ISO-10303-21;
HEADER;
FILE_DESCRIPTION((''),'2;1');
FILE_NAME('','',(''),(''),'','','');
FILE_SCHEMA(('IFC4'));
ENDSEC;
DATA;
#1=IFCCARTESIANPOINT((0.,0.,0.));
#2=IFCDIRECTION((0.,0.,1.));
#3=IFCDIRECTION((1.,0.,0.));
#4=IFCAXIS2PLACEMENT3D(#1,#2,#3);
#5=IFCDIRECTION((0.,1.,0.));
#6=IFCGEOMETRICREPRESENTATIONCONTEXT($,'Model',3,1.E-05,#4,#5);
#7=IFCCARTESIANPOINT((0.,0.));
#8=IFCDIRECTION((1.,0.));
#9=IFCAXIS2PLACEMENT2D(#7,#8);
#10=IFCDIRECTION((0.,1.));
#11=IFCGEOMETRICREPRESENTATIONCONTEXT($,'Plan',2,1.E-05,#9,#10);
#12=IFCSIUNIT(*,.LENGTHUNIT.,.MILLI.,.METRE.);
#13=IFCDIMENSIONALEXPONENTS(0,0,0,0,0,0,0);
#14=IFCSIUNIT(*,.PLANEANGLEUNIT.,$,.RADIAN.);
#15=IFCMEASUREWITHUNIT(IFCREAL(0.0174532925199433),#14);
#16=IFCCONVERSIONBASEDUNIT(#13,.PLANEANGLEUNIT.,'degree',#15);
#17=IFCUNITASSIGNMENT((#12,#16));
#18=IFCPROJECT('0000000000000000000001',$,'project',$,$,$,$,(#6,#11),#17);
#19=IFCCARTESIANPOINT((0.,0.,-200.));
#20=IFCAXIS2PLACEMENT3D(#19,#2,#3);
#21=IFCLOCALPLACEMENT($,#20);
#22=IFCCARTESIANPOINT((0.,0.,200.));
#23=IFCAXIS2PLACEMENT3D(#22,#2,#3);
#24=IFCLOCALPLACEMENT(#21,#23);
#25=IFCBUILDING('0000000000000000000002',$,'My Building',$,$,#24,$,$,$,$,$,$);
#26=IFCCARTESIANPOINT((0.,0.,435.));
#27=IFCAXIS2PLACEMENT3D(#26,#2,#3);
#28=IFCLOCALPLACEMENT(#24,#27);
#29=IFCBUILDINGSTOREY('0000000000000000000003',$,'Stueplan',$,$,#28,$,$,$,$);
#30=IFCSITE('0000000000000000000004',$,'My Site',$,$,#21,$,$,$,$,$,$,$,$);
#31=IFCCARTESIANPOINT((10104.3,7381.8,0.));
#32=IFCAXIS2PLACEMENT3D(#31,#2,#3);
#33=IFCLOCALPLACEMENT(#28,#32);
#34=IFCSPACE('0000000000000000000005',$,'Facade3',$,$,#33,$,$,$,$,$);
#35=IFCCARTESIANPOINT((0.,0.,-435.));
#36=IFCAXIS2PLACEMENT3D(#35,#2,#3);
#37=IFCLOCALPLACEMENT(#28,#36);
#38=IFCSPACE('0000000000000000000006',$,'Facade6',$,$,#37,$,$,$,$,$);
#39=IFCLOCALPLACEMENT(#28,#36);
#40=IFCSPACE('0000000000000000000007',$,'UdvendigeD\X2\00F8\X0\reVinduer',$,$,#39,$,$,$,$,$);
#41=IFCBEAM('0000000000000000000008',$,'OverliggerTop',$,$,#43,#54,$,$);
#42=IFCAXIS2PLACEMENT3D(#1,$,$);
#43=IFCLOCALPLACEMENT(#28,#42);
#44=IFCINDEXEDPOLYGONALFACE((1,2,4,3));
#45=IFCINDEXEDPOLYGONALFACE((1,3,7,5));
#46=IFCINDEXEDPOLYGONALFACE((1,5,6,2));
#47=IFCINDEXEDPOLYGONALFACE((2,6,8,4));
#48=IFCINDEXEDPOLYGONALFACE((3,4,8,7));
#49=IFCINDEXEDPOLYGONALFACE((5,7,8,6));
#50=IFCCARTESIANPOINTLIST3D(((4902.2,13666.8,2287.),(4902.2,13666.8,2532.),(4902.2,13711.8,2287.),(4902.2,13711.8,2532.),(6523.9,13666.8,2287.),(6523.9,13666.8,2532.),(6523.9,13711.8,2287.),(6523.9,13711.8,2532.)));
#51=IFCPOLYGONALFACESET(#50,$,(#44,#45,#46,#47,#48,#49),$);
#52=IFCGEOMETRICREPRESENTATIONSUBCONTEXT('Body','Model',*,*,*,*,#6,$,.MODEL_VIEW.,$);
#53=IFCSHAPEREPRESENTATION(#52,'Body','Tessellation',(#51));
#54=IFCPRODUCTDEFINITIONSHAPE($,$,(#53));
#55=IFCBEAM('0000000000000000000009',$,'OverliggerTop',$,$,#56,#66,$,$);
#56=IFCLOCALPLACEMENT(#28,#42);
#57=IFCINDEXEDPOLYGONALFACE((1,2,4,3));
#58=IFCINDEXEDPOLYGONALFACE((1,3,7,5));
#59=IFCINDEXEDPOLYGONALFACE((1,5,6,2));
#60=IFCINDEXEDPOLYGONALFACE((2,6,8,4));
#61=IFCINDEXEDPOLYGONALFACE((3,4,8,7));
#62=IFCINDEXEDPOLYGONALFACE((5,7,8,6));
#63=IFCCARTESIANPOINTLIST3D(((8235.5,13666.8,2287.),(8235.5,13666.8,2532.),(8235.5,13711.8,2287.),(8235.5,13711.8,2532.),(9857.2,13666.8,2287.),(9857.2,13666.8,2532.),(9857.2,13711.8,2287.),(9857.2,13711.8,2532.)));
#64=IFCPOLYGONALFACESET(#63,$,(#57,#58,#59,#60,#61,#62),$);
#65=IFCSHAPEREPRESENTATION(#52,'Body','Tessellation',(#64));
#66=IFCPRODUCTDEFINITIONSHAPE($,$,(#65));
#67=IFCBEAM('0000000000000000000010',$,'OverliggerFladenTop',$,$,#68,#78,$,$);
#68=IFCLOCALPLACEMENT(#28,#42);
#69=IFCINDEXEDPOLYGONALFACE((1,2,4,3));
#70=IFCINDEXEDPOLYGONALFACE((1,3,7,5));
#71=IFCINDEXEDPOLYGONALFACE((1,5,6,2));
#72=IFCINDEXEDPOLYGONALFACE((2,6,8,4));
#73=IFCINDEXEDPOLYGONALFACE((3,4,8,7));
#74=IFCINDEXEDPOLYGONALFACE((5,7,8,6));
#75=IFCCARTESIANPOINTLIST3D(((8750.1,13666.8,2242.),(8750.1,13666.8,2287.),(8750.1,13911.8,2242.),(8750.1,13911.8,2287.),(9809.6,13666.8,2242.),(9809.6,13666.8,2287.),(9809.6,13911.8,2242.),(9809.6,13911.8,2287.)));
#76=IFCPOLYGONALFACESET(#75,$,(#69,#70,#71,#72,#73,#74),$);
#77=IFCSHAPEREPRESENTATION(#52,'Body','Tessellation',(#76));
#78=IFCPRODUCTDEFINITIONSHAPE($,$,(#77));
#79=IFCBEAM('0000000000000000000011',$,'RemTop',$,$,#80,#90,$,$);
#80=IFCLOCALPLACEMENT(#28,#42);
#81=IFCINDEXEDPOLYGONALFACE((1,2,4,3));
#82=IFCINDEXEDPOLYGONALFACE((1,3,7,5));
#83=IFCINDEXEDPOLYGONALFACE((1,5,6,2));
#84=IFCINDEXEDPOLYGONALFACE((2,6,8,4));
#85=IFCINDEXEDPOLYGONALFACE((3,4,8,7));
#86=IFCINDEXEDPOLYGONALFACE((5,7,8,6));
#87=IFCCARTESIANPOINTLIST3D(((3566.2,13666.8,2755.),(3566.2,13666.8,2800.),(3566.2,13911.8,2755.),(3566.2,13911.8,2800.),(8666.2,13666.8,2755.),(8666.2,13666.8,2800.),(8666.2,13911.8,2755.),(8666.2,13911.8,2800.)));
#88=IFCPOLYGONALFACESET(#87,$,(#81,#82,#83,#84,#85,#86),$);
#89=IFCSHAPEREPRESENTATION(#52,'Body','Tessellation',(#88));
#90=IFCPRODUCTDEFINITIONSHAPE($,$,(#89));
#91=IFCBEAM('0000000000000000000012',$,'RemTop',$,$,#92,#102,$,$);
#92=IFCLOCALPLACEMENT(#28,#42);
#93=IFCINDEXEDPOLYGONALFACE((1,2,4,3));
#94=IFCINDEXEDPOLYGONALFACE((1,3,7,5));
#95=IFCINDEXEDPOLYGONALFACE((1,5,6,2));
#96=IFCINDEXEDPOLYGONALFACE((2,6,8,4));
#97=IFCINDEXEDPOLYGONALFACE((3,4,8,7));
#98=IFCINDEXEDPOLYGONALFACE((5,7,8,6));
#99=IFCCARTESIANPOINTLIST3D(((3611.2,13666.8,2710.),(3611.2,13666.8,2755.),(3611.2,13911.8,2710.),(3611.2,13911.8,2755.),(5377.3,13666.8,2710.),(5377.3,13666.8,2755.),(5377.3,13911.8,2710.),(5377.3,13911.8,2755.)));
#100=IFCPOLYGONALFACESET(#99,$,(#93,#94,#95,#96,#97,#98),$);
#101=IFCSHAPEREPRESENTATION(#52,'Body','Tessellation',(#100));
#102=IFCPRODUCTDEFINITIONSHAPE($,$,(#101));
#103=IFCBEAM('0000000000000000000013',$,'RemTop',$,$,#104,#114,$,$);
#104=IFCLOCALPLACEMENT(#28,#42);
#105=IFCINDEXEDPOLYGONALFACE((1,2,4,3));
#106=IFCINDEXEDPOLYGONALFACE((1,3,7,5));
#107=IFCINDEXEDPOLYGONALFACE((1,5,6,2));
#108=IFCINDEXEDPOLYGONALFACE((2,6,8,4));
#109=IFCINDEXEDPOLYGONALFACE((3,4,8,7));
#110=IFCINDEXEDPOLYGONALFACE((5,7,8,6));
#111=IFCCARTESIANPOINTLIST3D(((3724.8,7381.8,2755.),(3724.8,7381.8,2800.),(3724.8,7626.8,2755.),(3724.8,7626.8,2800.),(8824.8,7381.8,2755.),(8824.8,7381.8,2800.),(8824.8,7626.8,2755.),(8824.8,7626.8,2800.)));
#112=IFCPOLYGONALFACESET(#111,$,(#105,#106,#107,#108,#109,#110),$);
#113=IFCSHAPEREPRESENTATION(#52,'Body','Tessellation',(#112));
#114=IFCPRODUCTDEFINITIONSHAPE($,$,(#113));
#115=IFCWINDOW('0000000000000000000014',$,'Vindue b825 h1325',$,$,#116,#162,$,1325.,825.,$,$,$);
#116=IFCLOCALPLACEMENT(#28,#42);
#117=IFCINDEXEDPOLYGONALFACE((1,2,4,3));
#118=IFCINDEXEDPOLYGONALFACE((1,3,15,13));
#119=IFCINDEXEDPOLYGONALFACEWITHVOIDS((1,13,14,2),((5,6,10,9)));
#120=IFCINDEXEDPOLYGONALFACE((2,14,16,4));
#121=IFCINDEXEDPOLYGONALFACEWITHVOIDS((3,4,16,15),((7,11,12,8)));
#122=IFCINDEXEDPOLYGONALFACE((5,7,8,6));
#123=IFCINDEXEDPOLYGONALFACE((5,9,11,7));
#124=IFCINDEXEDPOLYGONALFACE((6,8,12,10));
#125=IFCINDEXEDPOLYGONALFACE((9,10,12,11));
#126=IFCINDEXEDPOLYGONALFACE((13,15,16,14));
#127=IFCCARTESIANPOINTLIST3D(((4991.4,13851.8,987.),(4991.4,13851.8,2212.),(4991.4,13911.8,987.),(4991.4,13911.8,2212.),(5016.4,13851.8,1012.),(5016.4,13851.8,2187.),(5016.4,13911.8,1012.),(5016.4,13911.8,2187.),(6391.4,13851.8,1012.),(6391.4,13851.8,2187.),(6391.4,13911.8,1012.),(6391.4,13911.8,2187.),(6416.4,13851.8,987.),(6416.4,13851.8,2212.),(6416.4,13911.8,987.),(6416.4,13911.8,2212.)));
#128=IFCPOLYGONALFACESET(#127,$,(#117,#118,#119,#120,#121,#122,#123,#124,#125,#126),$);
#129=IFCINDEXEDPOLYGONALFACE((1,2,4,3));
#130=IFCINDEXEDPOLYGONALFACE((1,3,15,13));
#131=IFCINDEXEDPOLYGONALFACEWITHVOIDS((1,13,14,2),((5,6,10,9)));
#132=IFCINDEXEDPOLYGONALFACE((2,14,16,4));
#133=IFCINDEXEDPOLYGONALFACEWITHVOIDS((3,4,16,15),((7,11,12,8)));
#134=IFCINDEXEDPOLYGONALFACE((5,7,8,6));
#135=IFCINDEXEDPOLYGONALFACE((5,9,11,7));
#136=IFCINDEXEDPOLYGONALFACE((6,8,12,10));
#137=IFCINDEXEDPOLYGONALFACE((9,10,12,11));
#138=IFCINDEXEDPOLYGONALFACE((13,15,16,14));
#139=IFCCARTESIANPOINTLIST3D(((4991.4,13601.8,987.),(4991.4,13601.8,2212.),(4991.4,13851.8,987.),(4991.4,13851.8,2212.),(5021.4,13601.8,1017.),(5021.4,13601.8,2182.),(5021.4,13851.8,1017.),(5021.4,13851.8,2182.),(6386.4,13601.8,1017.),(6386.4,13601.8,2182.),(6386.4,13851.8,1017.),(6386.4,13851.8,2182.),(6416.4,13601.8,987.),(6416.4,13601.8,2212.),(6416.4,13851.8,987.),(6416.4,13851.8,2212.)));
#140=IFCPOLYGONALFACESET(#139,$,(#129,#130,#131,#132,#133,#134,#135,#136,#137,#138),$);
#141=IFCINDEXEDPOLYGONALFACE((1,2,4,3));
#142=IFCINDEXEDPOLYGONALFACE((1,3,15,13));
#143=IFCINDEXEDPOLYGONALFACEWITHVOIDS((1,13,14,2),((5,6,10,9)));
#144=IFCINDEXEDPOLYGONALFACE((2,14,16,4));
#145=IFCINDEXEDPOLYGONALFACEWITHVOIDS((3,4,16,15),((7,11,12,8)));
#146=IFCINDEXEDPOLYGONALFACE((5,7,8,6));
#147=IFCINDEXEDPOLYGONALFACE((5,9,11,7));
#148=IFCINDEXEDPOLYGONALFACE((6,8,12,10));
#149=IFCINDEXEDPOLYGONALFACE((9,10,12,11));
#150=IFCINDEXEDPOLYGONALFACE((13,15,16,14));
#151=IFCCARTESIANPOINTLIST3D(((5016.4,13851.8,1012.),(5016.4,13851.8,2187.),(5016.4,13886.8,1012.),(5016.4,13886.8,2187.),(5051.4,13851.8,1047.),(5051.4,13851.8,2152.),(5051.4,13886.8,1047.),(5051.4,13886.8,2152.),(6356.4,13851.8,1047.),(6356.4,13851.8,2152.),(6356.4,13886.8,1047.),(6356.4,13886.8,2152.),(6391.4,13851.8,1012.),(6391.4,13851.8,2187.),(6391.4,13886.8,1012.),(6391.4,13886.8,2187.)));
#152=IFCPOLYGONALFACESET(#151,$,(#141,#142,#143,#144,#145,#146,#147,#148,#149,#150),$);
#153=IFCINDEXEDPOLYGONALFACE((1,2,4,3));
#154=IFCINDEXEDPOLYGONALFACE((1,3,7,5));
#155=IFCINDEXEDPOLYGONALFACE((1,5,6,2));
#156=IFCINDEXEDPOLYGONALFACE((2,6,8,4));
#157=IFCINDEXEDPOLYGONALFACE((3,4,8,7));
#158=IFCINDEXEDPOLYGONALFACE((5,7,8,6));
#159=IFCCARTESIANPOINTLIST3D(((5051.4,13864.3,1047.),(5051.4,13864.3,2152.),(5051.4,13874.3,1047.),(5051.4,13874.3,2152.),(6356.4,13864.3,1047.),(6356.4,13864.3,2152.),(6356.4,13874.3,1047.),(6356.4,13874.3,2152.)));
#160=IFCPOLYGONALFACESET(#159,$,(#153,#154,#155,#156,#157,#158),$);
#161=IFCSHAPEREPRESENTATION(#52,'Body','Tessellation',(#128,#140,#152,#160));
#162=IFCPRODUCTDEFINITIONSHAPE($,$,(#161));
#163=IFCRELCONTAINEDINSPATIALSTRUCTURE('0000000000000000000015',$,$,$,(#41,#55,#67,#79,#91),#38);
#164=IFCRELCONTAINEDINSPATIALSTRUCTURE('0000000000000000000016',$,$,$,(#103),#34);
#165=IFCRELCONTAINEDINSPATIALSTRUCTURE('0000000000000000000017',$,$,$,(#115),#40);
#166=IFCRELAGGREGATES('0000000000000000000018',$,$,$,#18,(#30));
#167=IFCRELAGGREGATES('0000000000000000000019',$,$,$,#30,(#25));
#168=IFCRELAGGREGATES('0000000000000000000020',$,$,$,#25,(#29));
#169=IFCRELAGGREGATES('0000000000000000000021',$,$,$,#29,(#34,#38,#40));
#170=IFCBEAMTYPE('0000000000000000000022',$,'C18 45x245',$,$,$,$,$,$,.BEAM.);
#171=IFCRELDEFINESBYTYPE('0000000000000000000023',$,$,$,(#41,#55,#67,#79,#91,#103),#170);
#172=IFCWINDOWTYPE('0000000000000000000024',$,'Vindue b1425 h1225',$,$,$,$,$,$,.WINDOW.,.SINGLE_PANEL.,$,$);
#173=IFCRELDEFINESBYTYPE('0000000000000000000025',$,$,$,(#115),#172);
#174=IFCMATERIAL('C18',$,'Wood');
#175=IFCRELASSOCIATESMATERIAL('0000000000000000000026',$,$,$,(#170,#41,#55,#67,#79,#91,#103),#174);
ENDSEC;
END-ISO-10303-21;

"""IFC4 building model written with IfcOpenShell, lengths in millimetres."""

from ifc_helpers import new_model, entity, si_unit, converted_unit, direction, frame, origin_with_axes, origin_2d_with_axis, place, context, subcontext, project, spatial, line, indexed_curve, rectangle, outline, extrude, shape, source, transform, mapped, material, material_profile, profile_set, profile_usage, type_object, type_shapes, element, save


model = new_model("IFC4")

# Units and contexts
model_context = context("Model", 3, precision=1e-05, world=origin_with_axes(), true_north=direction((0.0, 1.0, 0.0)))
plan_context = context("Plan", 2, precision=1e-05, world=origin_2d_with_axis(), true_north=direction((0.0, 1.0)))
body_context_1 = subcontext(model_context, "Body", "Model", "MODEL_VIEW")
body_context_2 = subcontext(plan_context, "Body", "Plan", "PLAN_VIEW")
ifc_project = project(units=[si_unit("LENGTHUNIT", "METRE", prefix="MILLI"), converted_unit("PLANEANGLEUNIT", "degree", entity("IfcReal", 0.0174532925199433), si_unit("PLANEANGLEUNIT", "RADIAN"), dimensions=[0, 0, 0, 0, 0, 0, 0])], contexts=[model_context, plan_context])

# Site, building, storey, space
site_placement = place(None, frame((0.0, 0.0, -200.0), z_axis=(0.0, 0.0, 1.0), x_axis=(1.0, 0.0, 0.0)))
site = spatial("IfcSite", under=ifc_project, at=site_placement, Name="My Site")
building_placement = place(site_placement, frame((0.0, 0.0, 200.0), z_axis=(0.0, 0.0, 1.0), x_axis=(1.0, 0.0, 0.0)))
building = spatial("IfcBuilding", under=site, at=building_placement, Name="My Building")
storey_placement = place(building_placement, frame((0.0, 0.0, 435.0), z_axis=(0.0, 0.0, 1.0), x_axis=(1.0, 0.0, 0.0)))
storey = spatial("IfcBuildingStorey", under=building, at=storey_placement, Name="Stueplan")
space_1_placement = place(storey_placement, frame((10104.3, 7381.8, 0.0), z_axis=(0.0, 0.0, 1.0), x_axis=(1.0, 0.0, 0.0)))
space_1 = spatial("IfcSpace", under=storey, at=space_1_placement, Name="Facade3")

# Shared definitions
ifc_material = material(Name="C18", Category="Wood")

# Shared definitions
space_2_placement = place(storey_placement, frame((0.0, 0.0, -435.0), z_axis=(0.0, 0.0, 1.0), x_axis=(1.0, 0.0, 0.0)))
space_2 = spatial("IfcSpace", under=storey, at=space_2_placement, Name="Facade6")

# Beams
ifc_material_profile_1 = material_profile(ifc_material, rectangle(XDim=45.0, YDim=245.0), Name="concrete")
ifc_profile_set_1 = profile_set([ifc_material_profile_1], Name="woodStructural")
beam_type = type_object("IfcBeamType", Name="C18 45x245", PredefinedType="BEAM", material=ifc_profile_set_1)
ifc_profile_usage_1 = profile_usage(ifc_profile_set_1)
beam_1_placement = place(space_2_placement, frame((4902.2, 13689.3, 2844.5), z_axis=(1.0, 0.0, 0.0), x_axis=(0.0, -1.0, 0.0)))
element("IfcBeam", 1, at=beam_1_placement, inside=space_2, type_object=beam_type, material=ifc_profile_usage_1, Name="OverliggerTop", context=body_context_1, shape_type="SweptSolid", body=[
    extrude(rectangle(XDim=45.0, YDim=245.0), origin_with_axes(), (0.0, 0.0, 1.0), 1621.7),
])
ifc_profile_usage_2 = profile_usage(ifc_profile_set_1)
beam_2_placement = place(space_2_placement, frame((8235.5, 13689.3, 2844.5), z_axis=(1.0, 0.0, 0.0), x_axis=(0.0, -1.0, 0.0)))
element("IfcBeam", 2, at=beam_2_placement, inside=space_2, type_object=beam_type, material=ifc_profile_usage_2, Name="OverliggerTop", context=body_context_1, shape_type="SweptSolid", body=[
    extrude(rectangle(XDim=45.0, YDim=245.0), origin_with_axes(), (0.0, 0.0, 1.0), 1621.7),
])
ifc_profile_usage_3 = profile_usage(ifc_profile_set_1)
beam_3_placement = place(space_2_placement, frame((9809.6, 13789.3, 2699.5), z_axis=(-1.0, 0.0, 0.0), x_axis=(0.0, 0.0, 1.0)))
element("IfcBeam", 3, at=beam_3_placement, inside=space_2, type_object=beam_type, material=ifc_profile_usage_3, Name="OverliggerFladenTop", context=body_context_1, shape_type="SweptSolid", body=[
    extrude(rectangle(XDim=45.0, YDim=245.0), origin_with_axes(), (0.0, 0.0, 1.0), 1059.5),
])
ifc_profile_usage_4 = profile_usage(ifc_profile_set_1)
beam_4_placement = place(space_2_placement, frame((8666.2, 13789.3, 3212.5), z_axis=(-1.0, 0.0, 0.0), x_axis=(0.0, 0.0, 1.0)))
element("IfcBeam", 4, at=beam_4_placement, inside=space_2, type_object=beam_type, material=ifc_profile_usage_4, Name="RemTop", context=body_context_1, shape_type="SweptSolid", body=[
    extrude(rectangle(XDim=45.0, YDim=245.0), origin_with_axes(), (0.0, 0.0, 1.0), 5100.0),
])
ifc_profile_usage_5 = profile_usage(ifc_profile_set_1)
beam_5_placement = place(space_2_placement, frame((5377.3, 13789.3, 3167.5), z_axis=(-1.0, 0.0, 0.0), x_axis=(0.0, 0.0, 1.0)))
element("IfcBeam", 5, at=beam_5_placement, inside=space_2, type_object=beam_type, material=ifc_profile_usage_5, Name="RemTop", context=body_context_1, shape_type="SweptSolid", body=[
    extrude(rectangle(XDim=45.0, YDim=245.0), origin_with_axes(), (0.0, 0.0, 1.0), 1766.1),
])
ifc_profile_usage_6 = profile_usage(ifc_profile_set_1)
beam_6_placement = place(space_1_placement, frame((-1279.6, 122.5, 2777.5), z_axis=(-1.0, 0.0, 0.0), x_axis=(0.0, 0.0, 1.0)))
element("IfcBeam", 6, at=beam_6_placement, inside=space_1, type_object=beam_type, material=ifc_profile_usage_6, Name="RemTop", context=body_context_1, shape_type="SweptSolid", body=[
    extrude(rectangle(XDim=45.0, YDim=245.0), origin_with_axes(), (0.0, 0.0, 1.0), 5100.0),
])

# Shared definitions
space_3_placement = place(storey_placement, frame((0.0, 0.0, -435.0), z_axis=(0.0, 0.0, 1.0), x_axis=(1.0, 0.0, 0.0)))
space_3 = spatial("IfcSpace", under=storey, at=space_3_placement, Name="UdvendigeDøreVinduer")

# Window
window_type = type_object("IfcWindowType", Name="Vindue b1425 h1225", PartitioningType="SINGLE_PANEL", PredefinedType="WINDOW")
shared_shape_1 = source(origin_with_axes(), body_context_1, "Body", "SweptSolid", [
    extrude(outline(indexed_curve([(0.0, 0.0), (1425.0, 0.0), (1425.0, 1225.0), (0.0, 1225.0)], segments=[line(1, 2, 3, 4, 1)]), holes=[indexed_curve([(25.0, 25.0), (1400.0, 25.0), (1400.0, 1200.0), (25.0, 1200.0)], segments=[line(1, 2, 3, 4, 1)])]), frame((0.0, 250.0, 0.0), z_axis=(0.0, -1.0, 0.0), x_axis=(1.0, 0.0, 0.0)), (0.0, 0.0, -1.0), 60.0),
    extrude(outline(indexed_curve([(0.0, 0.0), (1425.0, 0.0), (1425.0, 1225.0), (0.0, 1225.0)], segments=[line(1, 2, 3, 4, 1)]), holes=[indexed_curve([(30.0, 30.0), (1395.0, 30.0), (1395.0, 1195.0), (30.0, 1195.0)], segments=[line(1, 2, 3, 4, 1)])]), frame((0.0, 0.0, 0.0), z_axis=(0.0, -1.0, 0.0), x_axis=(1.0, 0.0, 0.0)), (0.0, 0.0, -1.0), 250.0),
    extrude(outline(indexed_curve([(0.0, 0.0), (1375.0, 0.0), (1375.0, 1175.0), (0.0, 1175.0)], segments=[line(1, 2, 3, 4, 1)]), holes=[indexed_curve([(35.0, 35.0), (1340.0, 35.0), (1340.0, 1140.0), (35.0, 1140.0)], segments=[line(1, 2, 3, 4, 1)])]), frame((25.0, 250.0, 25.0), z_axis=(0.0, -1.0, 0.0), x_axis=(1.0, 0.0, 0.0)), (0.0, 0.0, -1.0), 35.0),
    extrude(outline(indexed_curve([(35.0, 35.0), (1340.0, 35.0), (1340.0, 1140.0), (35.0, 1140.0)], segments=[line(1, 2, 3, 4, 1)])), frame((25.0, 262.5, 25.0), z_axis=(0.0, -1.0, 0.0), x_axis=(1.0, 0.0, 0.0)), (0.0, 0.0, -1.0), 10.0),
])
shared_shape_2 = source(origin_with_axes(), body_context_2, "Body", "Curve2D", [
    entity("IfcIndexedPolyCurve", entity("IfcCartesianPointList2D", [[30.0, 0.0], [1395.0, 0.0]])),
    entity("IfcIndexedPolyCurve", entity("IfcCartesianPointList2D", [[0.0, 310.0], [25.0, 310.0], [25.0, 250.0], [30.0, 250.0], [30.0, 0.0], [0.0, 0.0]]), [entity("IfcLineIndex", [1, 2, 3, 4, 5, 6, 1])]),
    entity("IfcIndexedPolyCurve", entity("IfcCartesianPointList2D", [[1425.0, 310.0], [1400.0, 310.0], [1400.0, 250.0], [1395.0, 250.0], [1395.0, 0.0], [1425.0, 0.0]]), [entity("IfcLineIndex", [1, 2, 3, 4, 5, 6, 1])]),
    entity("IfcIndexedPolyCurve", entity("IfcCartesianPointList2D", [[25.0, 250.0], [60.0, 250.0], [60.0, 285.0], [25.0, 285.0]]), [entity("IfcLineIndex", [1, 2, 3, 4, 1])]),
    entity("IfcIndexedPolyCurve", entity("IfcCartesianPointList2D", [[1400.0, 250.0], [1365.0, 250.0], [1365.0, 285.0], [1400.0, 285.0]]), [entity("IfcLineIndex", [1, 2, 3, 4, 1])]),
    entity("IfcIndexedPolyCurve", entity("IfcCartesianPointList2D", [[60.0, 250.0], [1365.0, 250.0]])),
    entity("IfcIndexedPolyCurve", entity("IfcCartesianPointList2D", [[60.0, 285.0], [1365.0, 285.0]])),
    entity("IfcIndexedPolyCurve", entity("IfcCartesianPointList2D", [[60.0, 267.5], [1365.0, 267.5]])),
])
type_shapes(window_type, [shared_shape_1, shared_shape_2])
window_placement = place(space_3_placement, frame((4991.4, 13601.8, 1422.0), z_axis=(0.0, 0.0, 1.0), x_axis=(1.0, 0.0, 0.0)))
element("IfcWindow", 7, at=window_placement, inside=space_3, type_object=window_type, Name="Vindue b825 h1325", OverallHeight=1325.0, OverallWidth=825.0, shapes=[
    shape(body_context_1, "Body", "MappedRepresentation", [mapped(shared_shape_1, transform((0.0, 0.0, 0.0), x_axis=(1.0, 0.0, 0.0), y_axis=(0.0, 1.0, 0.0), z_axis=(0.0, 0.0, 1.0), scale=1.0))]),
    shape(body_context_2, "Body", "MappedRepresentation", [mapped(shared_shape_2, transform((0.0, 0.0, 0.0), x_axis=(1.0, 0.0, 0.0), y_axis=(0.0, 1.0, 0.0), z_axis=(0.0, 0.0, 1.0), scale=1.0))]),
])

save(model, "model.ifc")
